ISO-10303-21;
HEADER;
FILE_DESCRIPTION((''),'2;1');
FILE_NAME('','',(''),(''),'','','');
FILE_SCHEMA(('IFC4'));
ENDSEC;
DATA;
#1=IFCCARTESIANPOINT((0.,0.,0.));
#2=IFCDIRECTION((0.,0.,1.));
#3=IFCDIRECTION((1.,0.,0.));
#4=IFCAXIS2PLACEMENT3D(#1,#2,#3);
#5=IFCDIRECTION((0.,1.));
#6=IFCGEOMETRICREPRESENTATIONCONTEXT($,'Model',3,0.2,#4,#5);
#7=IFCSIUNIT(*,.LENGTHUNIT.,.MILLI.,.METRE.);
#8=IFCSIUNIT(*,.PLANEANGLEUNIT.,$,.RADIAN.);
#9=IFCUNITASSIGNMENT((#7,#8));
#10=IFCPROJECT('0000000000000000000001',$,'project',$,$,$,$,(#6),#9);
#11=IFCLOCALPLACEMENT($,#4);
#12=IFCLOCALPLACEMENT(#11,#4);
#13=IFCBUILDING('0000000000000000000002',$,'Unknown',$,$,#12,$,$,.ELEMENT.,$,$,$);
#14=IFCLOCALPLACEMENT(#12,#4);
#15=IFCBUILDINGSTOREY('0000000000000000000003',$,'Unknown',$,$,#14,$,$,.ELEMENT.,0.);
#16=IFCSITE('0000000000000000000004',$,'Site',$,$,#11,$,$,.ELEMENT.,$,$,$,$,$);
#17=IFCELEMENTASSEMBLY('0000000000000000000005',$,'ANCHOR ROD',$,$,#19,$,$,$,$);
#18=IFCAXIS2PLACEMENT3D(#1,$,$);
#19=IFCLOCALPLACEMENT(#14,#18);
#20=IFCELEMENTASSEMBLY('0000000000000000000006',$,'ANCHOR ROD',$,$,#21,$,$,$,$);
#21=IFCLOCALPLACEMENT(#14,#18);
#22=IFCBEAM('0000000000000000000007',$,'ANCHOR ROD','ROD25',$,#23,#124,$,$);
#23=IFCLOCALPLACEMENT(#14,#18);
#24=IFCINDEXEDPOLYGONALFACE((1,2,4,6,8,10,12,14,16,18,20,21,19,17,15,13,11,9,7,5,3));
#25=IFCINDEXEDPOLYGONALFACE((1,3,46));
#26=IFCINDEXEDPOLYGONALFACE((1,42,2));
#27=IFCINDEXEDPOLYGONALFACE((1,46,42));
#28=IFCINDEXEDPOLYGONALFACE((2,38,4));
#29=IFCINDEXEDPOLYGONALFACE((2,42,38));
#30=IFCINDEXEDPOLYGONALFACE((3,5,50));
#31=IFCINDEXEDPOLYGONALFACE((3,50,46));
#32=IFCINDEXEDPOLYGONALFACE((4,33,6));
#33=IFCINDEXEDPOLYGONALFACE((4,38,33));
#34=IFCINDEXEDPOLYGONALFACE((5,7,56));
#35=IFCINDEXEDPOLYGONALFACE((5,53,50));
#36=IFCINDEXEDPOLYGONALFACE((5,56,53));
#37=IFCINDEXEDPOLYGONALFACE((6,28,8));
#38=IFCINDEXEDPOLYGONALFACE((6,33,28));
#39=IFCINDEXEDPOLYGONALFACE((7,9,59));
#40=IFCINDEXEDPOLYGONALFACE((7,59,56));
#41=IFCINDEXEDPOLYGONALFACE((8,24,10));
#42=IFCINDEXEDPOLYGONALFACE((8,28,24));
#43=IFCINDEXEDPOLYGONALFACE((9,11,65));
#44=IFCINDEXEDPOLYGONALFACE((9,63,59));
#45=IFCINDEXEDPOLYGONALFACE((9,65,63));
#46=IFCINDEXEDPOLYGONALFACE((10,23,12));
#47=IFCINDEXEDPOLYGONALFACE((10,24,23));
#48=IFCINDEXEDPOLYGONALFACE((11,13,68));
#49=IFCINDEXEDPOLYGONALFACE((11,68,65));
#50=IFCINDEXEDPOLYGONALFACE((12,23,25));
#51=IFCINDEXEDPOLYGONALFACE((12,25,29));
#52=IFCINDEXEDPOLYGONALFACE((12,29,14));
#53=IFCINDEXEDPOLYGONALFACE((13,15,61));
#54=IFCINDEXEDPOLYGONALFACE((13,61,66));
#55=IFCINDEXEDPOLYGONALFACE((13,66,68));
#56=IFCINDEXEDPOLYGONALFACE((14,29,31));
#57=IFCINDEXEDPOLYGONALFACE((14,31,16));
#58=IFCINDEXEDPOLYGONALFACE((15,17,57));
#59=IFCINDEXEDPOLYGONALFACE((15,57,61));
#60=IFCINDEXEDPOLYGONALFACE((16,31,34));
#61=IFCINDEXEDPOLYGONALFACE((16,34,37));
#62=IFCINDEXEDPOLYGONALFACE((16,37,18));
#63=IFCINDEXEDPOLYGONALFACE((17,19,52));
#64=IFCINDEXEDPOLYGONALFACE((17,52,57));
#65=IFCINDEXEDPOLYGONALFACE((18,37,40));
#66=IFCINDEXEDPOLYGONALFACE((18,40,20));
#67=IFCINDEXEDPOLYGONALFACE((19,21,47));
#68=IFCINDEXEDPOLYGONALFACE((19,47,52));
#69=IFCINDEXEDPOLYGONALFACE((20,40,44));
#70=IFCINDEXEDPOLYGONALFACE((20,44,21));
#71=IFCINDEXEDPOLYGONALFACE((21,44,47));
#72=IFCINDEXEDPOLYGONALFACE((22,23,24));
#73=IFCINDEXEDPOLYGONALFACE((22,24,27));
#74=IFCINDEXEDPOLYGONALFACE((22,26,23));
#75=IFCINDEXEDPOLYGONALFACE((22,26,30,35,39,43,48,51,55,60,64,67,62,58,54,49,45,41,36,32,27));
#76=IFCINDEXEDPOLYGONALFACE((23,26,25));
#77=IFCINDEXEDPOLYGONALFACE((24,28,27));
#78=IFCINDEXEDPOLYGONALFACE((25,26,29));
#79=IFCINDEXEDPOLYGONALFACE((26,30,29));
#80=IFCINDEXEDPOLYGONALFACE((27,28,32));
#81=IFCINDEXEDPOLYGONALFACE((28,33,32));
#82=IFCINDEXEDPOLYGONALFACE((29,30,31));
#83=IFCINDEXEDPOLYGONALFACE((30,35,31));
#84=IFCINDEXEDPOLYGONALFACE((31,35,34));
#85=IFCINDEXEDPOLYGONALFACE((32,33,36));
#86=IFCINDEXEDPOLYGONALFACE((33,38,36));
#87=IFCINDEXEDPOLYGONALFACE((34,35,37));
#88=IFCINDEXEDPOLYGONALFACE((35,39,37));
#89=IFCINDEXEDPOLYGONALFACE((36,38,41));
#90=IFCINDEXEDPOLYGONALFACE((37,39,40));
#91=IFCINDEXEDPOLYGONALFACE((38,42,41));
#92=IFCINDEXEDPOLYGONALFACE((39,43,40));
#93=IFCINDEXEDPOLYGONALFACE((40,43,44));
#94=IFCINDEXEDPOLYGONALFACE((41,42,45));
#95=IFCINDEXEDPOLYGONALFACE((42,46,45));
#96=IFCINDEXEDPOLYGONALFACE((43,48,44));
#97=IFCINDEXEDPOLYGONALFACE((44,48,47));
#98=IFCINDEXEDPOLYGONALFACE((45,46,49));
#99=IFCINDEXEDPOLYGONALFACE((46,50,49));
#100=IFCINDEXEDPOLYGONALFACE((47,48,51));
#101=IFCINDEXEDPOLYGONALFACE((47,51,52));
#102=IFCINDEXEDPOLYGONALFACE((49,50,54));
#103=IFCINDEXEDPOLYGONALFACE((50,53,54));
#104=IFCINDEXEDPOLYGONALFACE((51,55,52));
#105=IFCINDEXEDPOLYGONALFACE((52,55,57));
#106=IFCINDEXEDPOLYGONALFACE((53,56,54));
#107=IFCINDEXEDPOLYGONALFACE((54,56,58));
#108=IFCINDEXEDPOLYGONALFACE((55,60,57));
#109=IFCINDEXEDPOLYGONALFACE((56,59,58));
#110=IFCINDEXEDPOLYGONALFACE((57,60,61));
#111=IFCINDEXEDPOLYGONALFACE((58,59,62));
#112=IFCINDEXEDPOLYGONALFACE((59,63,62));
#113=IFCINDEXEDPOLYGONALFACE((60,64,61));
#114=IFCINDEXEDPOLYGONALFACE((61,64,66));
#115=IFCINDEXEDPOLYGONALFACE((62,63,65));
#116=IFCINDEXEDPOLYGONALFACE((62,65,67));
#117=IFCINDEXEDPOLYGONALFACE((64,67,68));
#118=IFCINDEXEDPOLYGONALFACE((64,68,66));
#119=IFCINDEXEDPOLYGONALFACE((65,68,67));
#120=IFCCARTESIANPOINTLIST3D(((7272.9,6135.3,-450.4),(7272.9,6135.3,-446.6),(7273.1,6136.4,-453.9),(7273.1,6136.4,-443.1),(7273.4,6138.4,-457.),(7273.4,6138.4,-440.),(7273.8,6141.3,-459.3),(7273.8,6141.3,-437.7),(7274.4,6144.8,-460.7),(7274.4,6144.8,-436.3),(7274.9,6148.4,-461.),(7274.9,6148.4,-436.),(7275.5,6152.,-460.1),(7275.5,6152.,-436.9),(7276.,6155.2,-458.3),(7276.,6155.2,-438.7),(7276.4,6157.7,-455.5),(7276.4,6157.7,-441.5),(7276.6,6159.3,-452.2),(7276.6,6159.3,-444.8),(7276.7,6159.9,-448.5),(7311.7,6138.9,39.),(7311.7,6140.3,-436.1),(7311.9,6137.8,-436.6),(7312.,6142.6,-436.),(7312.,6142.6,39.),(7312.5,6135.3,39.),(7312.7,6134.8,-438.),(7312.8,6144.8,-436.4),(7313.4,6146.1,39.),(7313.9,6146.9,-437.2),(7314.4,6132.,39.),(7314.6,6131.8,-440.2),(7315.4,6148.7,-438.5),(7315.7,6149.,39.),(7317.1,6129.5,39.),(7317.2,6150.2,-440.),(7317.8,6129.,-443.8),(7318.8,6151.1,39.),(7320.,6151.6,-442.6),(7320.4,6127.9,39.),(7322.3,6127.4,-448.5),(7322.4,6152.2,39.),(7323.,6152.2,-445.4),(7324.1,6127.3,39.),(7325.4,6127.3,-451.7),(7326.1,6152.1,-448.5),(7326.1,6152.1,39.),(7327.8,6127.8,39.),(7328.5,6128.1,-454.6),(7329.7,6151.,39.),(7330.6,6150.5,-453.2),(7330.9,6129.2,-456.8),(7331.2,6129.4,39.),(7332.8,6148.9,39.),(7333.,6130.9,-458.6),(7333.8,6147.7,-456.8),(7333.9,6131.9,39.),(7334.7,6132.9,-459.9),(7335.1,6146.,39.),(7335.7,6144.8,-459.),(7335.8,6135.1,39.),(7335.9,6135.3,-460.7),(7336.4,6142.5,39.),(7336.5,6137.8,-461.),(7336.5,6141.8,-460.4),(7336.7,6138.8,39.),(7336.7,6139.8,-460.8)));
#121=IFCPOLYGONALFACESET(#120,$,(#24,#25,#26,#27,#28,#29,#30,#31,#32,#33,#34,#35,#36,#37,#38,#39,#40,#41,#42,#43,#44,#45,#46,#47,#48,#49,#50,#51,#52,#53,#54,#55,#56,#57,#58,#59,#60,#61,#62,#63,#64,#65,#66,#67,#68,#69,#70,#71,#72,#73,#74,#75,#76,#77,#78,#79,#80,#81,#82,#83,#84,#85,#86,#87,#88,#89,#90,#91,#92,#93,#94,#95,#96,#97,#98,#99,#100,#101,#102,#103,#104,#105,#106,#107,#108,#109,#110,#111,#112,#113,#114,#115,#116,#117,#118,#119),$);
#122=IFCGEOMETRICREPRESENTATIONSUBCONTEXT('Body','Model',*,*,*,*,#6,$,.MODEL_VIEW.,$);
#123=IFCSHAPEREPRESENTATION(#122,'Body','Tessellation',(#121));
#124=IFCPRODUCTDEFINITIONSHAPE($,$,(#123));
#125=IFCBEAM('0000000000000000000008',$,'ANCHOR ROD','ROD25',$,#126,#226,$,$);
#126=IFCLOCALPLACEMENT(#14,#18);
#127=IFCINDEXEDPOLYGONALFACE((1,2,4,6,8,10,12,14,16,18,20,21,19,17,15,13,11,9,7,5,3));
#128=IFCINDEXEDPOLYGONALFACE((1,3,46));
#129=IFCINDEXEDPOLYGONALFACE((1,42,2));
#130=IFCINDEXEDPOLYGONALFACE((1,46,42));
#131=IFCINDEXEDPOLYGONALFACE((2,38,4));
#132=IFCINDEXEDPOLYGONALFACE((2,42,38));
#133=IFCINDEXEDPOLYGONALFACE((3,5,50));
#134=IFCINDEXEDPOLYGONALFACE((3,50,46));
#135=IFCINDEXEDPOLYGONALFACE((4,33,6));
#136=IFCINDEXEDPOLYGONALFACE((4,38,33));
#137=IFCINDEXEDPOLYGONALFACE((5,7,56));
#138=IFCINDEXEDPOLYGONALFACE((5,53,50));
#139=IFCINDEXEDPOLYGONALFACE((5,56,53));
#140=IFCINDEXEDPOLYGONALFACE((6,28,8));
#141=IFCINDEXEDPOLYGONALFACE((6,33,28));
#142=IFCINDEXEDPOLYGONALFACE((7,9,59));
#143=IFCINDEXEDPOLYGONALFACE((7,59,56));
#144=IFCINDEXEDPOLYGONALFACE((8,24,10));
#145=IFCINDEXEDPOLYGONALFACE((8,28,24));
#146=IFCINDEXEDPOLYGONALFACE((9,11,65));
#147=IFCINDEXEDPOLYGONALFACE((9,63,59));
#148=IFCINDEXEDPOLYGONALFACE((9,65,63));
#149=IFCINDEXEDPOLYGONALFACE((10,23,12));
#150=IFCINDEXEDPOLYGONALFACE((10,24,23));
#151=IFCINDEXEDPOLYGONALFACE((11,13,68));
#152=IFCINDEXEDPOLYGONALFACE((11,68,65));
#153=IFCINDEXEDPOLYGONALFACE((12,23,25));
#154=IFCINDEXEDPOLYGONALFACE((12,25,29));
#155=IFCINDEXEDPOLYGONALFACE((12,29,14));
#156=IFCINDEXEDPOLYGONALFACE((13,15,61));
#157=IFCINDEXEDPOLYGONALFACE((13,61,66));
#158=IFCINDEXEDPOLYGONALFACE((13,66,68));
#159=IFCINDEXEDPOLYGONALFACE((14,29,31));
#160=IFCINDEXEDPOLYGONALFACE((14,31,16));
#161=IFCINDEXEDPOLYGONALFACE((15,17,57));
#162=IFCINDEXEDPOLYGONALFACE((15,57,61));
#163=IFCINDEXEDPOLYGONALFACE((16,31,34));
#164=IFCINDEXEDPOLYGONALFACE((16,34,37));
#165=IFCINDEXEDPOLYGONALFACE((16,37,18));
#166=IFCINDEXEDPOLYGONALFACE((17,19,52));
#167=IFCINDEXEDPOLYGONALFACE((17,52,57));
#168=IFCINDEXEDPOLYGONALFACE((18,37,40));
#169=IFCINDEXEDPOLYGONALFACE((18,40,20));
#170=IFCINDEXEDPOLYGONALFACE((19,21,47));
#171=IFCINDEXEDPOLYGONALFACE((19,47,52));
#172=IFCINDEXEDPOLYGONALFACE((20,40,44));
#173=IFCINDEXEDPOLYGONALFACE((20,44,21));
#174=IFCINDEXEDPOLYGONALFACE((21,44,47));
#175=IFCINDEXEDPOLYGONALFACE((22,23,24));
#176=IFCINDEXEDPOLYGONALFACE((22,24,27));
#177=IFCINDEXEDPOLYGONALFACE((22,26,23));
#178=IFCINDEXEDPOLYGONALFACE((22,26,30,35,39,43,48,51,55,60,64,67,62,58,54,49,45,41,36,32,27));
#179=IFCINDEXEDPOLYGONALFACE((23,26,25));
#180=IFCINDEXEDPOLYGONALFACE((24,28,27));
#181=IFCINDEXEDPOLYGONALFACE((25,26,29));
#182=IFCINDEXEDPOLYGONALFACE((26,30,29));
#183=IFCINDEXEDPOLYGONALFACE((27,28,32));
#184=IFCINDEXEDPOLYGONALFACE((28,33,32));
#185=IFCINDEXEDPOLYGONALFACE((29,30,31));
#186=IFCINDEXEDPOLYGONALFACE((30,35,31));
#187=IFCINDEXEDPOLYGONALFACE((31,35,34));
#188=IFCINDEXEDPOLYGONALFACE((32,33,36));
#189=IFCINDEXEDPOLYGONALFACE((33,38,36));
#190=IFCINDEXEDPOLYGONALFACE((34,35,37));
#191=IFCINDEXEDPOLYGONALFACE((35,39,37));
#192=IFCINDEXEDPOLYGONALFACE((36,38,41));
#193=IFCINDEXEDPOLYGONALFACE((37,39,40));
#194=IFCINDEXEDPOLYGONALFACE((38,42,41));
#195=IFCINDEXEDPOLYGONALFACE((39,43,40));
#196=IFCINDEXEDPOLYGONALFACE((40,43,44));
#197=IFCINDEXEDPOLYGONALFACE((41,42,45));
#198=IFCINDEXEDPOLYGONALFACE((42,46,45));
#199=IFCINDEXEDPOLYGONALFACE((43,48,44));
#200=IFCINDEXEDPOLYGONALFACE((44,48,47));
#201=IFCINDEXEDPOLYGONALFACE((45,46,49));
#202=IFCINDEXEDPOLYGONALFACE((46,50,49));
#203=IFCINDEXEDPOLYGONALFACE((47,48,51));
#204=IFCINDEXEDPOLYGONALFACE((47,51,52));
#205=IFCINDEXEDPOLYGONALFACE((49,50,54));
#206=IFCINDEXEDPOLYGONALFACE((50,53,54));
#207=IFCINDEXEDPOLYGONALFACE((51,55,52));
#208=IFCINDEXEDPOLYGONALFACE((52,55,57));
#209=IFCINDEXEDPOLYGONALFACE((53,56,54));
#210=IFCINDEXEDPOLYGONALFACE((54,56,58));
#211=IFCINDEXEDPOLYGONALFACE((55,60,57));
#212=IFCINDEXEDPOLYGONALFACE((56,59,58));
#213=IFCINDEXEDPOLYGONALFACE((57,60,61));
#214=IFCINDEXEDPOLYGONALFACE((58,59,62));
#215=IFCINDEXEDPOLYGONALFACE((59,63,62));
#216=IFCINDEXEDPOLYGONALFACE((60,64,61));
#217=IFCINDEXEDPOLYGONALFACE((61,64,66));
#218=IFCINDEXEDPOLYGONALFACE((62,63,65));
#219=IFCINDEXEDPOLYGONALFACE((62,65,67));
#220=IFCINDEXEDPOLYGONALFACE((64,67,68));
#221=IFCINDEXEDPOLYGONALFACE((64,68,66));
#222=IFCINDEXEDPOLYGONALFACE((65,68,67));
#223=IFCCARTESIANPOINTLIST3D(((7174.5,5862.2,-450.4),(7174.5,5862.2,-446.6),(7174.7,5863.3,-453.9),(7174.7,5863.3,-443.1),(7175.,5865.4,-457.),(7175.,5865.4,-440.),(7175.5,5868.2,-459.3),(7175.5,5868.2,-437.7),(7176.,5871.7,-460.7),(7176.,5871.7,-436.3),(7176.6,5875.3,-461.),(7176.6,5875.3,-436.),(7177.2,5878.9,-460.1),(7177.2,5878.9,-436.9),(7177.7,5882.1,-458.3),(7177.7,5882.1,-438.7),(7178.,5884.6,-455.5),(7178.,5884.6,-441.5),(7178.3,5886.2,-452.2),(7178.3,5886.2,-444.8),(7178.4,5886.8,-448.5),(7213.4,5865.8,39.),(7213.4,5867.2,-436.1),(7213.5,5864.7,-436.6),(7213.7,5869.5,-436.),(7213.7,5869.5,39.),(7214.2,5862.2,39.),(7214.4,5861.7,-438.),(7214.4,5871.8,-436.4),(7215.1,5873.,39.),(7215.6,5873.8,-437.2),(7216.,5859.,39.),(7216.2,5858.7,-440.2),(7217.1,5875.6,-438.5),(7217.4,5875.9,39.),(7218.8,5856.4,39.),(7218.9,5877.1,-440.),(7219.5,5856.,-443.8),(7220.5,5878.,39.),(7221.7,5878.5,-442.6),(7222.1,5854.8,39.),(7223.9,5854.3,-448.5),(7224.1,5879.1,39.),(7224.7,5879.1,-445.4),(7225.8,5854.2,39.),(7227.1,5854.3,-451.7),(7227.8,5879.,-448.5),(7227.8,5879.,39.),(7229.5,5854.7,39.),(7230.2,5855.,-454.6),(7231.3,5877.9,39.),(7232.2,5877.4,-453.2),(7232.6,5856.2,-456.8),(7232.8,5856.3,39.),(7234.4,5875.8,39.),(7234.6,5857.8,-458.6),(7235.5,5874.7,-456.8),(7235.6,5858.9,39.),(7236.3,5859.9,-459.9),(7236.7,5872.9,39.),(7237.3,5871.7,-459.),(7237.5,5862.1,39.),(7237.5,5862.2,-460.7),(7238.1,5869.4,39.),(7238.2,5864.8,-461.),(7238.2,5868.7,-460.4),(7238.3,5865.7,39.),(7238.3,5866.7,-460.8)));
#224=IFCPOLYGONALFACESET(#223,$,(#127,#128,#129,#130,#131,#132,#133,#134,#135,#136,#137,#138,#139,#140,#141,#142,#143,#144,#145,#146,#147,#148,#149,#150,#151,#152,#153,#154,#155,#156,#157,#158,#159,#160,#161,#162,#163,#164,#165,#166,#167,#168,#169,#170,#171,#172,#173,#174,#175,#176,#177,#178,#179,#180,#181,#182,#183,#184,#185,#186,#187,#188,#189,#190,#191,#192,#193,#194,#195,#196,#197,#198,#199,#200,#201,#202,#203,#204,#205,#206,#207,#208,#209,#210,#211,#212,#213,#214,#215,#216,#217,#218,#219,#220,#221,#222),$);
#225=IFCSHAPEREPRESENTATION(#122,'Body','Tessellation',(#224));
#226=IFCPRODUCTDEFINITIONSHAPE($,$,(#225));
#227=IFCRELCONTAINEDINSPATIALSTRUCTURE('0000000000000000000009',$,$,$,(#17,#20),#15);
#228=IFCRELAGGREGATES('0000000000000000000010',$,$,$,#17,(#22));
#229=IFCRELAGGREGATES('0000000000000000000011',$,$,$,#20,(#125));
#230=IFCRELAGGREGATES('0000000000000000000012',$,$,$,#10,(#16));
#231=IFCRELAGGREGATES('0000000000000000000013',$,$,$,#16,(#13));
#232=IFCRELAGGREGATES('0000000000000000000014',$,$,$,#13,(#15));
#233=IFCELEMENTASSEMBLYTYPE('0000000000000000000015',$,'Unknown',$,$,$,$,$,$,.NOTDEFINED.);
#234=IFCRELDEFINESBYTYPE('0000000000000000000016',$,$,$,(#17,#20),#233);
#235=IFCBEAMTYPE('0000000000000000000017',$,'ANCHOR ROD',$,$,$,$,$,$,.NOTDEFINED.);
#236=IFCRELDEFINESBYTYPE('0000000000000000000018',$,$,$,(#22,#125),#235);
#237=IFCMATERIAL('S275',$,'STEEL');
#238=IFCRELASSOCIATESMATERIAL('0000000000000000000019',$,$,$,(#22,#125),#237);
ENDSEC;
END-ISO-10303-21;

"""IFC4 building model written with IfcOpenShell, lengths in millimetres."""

from ifc_helpers import new_model, entity, si_unit, direction, frame, origin_with_axes, place, context, subcontext, project, spatial, material, type_object, element, aggregate, save


model = new_model("IFC4")

# Units and contexts
model_context = context("Model", 3, precision=0.2, world=origin_with_axes(), true_north=direction((0.0, 1.0)))
body_context = subcontext(model_context, "Body", "Model", "MODEL_VIEW")
ifc_project = project(units=[si_unit("LENGTHUNIT", "METRE", prefix="MILLI"), si_unit("PLANEANGLEUNIT", "RADIAN")], contexts=[model_context])

# Site, building, storey
site_placement = place(None, origin_with_axes())
site = spatial("IfcSite", under=ifc_project, at=site_placement, Name="Site", CompositionType="ELEMENT")
building_placement = place(site_placement, origin_with_axes())
building = spatial("IfcBuilding", under=site, at=building_placement, Name="Unknown", CompositionType="ELEMENT")
storey_placement = place(building_placement, origin_with_axes())
storey = spatial("IfcBuildingStorey", under=building, at=storey_placement, Name="Unknown", CompositionType="ELEMENT", Elevation=0.0)

# Element assemblies
element_assembly_type = type_object("IfcElementAssemblyType", Name="Unknown", PredefinedType="NOTDEFINED")
ifc_material_1 = material(Name="S275", Category="STEEL")
assembly_1_placement = place(storey_placement, frame((7324.2, 6139.8, 39.0), z_axis=(0.154417, 0.988006, 0.0), x_axis=(0.0, 0.0, -1.0)))
assembly_1 = element("IfcElementAssembly", 1, at=assembly_1_placement, inside=storey, type_object=element_assembly_type, Name="ANCHOR ROD")
assembly_2_placement = place(storey_placement, frame((7225.8, 5866.7, 39.0), z_axis=(0.154419, 0.988005, 0.0), x_axis=(0.0, 0.0, -1.0)))
assembly_2 = element("IfcElementAssembly", 2, at=assembly_2_placement, inside=storey, type_object=element_assembly_type, Name="ANCHOR ROD")

# Beams
beam_type_1 = type_object("IfcBeamType", Name="ANCHOR ROD", PredefinedType="NOTDEFINED")
beam_1_placement = place(assembly_1_placement, origin_with_axes())
beam_1 = element("IfcBeam", 3, at=beam_1_placement, type_object=beam_type_1, material=ifc_material_1, Name="ANCHOR ROD", Description="ROD25", context=body_context, shape_type="SolidModel", body=[
    entity("IfcSweptDiskSolid", entity("IfcIndexedPolyCurve", entity("IfcCartesianPointList3D", [[0.0, 0.0, 0.0], [487.5, 0.0, 0.0], [487.5, 50.0, 0.0]]), [entity("IfcLineIndex", [1, 2, 3])]), 12.5),
])
beam_2_placement = place(assembly_2_placement, origin_with_axes())
beam_2 = element("IfcBeam", 4, at=beam_2_placement, type_object=beam_type_1, material=ifc_material_1, Name="ANCHOR ROD", Description="ROD25", context=body_context, shape_type="SolidModel", body=[
    entity("IfcSweptDiskSolid", entity("IfcIndexedPolyCurve", entity("IfcCartesianPointList3D", [[0.0, 0.0, 0.0], [487.5, 0.0, 0.0], [487.5, 50.0, 0.0]]), [entity("IfcLineIndex", [1, 2, 3])]), 12.5),
])
aggregate(assembly_1, [beam_1])
aggregate(assembly_2, [beam_2])

save(model, "model.ifc")
